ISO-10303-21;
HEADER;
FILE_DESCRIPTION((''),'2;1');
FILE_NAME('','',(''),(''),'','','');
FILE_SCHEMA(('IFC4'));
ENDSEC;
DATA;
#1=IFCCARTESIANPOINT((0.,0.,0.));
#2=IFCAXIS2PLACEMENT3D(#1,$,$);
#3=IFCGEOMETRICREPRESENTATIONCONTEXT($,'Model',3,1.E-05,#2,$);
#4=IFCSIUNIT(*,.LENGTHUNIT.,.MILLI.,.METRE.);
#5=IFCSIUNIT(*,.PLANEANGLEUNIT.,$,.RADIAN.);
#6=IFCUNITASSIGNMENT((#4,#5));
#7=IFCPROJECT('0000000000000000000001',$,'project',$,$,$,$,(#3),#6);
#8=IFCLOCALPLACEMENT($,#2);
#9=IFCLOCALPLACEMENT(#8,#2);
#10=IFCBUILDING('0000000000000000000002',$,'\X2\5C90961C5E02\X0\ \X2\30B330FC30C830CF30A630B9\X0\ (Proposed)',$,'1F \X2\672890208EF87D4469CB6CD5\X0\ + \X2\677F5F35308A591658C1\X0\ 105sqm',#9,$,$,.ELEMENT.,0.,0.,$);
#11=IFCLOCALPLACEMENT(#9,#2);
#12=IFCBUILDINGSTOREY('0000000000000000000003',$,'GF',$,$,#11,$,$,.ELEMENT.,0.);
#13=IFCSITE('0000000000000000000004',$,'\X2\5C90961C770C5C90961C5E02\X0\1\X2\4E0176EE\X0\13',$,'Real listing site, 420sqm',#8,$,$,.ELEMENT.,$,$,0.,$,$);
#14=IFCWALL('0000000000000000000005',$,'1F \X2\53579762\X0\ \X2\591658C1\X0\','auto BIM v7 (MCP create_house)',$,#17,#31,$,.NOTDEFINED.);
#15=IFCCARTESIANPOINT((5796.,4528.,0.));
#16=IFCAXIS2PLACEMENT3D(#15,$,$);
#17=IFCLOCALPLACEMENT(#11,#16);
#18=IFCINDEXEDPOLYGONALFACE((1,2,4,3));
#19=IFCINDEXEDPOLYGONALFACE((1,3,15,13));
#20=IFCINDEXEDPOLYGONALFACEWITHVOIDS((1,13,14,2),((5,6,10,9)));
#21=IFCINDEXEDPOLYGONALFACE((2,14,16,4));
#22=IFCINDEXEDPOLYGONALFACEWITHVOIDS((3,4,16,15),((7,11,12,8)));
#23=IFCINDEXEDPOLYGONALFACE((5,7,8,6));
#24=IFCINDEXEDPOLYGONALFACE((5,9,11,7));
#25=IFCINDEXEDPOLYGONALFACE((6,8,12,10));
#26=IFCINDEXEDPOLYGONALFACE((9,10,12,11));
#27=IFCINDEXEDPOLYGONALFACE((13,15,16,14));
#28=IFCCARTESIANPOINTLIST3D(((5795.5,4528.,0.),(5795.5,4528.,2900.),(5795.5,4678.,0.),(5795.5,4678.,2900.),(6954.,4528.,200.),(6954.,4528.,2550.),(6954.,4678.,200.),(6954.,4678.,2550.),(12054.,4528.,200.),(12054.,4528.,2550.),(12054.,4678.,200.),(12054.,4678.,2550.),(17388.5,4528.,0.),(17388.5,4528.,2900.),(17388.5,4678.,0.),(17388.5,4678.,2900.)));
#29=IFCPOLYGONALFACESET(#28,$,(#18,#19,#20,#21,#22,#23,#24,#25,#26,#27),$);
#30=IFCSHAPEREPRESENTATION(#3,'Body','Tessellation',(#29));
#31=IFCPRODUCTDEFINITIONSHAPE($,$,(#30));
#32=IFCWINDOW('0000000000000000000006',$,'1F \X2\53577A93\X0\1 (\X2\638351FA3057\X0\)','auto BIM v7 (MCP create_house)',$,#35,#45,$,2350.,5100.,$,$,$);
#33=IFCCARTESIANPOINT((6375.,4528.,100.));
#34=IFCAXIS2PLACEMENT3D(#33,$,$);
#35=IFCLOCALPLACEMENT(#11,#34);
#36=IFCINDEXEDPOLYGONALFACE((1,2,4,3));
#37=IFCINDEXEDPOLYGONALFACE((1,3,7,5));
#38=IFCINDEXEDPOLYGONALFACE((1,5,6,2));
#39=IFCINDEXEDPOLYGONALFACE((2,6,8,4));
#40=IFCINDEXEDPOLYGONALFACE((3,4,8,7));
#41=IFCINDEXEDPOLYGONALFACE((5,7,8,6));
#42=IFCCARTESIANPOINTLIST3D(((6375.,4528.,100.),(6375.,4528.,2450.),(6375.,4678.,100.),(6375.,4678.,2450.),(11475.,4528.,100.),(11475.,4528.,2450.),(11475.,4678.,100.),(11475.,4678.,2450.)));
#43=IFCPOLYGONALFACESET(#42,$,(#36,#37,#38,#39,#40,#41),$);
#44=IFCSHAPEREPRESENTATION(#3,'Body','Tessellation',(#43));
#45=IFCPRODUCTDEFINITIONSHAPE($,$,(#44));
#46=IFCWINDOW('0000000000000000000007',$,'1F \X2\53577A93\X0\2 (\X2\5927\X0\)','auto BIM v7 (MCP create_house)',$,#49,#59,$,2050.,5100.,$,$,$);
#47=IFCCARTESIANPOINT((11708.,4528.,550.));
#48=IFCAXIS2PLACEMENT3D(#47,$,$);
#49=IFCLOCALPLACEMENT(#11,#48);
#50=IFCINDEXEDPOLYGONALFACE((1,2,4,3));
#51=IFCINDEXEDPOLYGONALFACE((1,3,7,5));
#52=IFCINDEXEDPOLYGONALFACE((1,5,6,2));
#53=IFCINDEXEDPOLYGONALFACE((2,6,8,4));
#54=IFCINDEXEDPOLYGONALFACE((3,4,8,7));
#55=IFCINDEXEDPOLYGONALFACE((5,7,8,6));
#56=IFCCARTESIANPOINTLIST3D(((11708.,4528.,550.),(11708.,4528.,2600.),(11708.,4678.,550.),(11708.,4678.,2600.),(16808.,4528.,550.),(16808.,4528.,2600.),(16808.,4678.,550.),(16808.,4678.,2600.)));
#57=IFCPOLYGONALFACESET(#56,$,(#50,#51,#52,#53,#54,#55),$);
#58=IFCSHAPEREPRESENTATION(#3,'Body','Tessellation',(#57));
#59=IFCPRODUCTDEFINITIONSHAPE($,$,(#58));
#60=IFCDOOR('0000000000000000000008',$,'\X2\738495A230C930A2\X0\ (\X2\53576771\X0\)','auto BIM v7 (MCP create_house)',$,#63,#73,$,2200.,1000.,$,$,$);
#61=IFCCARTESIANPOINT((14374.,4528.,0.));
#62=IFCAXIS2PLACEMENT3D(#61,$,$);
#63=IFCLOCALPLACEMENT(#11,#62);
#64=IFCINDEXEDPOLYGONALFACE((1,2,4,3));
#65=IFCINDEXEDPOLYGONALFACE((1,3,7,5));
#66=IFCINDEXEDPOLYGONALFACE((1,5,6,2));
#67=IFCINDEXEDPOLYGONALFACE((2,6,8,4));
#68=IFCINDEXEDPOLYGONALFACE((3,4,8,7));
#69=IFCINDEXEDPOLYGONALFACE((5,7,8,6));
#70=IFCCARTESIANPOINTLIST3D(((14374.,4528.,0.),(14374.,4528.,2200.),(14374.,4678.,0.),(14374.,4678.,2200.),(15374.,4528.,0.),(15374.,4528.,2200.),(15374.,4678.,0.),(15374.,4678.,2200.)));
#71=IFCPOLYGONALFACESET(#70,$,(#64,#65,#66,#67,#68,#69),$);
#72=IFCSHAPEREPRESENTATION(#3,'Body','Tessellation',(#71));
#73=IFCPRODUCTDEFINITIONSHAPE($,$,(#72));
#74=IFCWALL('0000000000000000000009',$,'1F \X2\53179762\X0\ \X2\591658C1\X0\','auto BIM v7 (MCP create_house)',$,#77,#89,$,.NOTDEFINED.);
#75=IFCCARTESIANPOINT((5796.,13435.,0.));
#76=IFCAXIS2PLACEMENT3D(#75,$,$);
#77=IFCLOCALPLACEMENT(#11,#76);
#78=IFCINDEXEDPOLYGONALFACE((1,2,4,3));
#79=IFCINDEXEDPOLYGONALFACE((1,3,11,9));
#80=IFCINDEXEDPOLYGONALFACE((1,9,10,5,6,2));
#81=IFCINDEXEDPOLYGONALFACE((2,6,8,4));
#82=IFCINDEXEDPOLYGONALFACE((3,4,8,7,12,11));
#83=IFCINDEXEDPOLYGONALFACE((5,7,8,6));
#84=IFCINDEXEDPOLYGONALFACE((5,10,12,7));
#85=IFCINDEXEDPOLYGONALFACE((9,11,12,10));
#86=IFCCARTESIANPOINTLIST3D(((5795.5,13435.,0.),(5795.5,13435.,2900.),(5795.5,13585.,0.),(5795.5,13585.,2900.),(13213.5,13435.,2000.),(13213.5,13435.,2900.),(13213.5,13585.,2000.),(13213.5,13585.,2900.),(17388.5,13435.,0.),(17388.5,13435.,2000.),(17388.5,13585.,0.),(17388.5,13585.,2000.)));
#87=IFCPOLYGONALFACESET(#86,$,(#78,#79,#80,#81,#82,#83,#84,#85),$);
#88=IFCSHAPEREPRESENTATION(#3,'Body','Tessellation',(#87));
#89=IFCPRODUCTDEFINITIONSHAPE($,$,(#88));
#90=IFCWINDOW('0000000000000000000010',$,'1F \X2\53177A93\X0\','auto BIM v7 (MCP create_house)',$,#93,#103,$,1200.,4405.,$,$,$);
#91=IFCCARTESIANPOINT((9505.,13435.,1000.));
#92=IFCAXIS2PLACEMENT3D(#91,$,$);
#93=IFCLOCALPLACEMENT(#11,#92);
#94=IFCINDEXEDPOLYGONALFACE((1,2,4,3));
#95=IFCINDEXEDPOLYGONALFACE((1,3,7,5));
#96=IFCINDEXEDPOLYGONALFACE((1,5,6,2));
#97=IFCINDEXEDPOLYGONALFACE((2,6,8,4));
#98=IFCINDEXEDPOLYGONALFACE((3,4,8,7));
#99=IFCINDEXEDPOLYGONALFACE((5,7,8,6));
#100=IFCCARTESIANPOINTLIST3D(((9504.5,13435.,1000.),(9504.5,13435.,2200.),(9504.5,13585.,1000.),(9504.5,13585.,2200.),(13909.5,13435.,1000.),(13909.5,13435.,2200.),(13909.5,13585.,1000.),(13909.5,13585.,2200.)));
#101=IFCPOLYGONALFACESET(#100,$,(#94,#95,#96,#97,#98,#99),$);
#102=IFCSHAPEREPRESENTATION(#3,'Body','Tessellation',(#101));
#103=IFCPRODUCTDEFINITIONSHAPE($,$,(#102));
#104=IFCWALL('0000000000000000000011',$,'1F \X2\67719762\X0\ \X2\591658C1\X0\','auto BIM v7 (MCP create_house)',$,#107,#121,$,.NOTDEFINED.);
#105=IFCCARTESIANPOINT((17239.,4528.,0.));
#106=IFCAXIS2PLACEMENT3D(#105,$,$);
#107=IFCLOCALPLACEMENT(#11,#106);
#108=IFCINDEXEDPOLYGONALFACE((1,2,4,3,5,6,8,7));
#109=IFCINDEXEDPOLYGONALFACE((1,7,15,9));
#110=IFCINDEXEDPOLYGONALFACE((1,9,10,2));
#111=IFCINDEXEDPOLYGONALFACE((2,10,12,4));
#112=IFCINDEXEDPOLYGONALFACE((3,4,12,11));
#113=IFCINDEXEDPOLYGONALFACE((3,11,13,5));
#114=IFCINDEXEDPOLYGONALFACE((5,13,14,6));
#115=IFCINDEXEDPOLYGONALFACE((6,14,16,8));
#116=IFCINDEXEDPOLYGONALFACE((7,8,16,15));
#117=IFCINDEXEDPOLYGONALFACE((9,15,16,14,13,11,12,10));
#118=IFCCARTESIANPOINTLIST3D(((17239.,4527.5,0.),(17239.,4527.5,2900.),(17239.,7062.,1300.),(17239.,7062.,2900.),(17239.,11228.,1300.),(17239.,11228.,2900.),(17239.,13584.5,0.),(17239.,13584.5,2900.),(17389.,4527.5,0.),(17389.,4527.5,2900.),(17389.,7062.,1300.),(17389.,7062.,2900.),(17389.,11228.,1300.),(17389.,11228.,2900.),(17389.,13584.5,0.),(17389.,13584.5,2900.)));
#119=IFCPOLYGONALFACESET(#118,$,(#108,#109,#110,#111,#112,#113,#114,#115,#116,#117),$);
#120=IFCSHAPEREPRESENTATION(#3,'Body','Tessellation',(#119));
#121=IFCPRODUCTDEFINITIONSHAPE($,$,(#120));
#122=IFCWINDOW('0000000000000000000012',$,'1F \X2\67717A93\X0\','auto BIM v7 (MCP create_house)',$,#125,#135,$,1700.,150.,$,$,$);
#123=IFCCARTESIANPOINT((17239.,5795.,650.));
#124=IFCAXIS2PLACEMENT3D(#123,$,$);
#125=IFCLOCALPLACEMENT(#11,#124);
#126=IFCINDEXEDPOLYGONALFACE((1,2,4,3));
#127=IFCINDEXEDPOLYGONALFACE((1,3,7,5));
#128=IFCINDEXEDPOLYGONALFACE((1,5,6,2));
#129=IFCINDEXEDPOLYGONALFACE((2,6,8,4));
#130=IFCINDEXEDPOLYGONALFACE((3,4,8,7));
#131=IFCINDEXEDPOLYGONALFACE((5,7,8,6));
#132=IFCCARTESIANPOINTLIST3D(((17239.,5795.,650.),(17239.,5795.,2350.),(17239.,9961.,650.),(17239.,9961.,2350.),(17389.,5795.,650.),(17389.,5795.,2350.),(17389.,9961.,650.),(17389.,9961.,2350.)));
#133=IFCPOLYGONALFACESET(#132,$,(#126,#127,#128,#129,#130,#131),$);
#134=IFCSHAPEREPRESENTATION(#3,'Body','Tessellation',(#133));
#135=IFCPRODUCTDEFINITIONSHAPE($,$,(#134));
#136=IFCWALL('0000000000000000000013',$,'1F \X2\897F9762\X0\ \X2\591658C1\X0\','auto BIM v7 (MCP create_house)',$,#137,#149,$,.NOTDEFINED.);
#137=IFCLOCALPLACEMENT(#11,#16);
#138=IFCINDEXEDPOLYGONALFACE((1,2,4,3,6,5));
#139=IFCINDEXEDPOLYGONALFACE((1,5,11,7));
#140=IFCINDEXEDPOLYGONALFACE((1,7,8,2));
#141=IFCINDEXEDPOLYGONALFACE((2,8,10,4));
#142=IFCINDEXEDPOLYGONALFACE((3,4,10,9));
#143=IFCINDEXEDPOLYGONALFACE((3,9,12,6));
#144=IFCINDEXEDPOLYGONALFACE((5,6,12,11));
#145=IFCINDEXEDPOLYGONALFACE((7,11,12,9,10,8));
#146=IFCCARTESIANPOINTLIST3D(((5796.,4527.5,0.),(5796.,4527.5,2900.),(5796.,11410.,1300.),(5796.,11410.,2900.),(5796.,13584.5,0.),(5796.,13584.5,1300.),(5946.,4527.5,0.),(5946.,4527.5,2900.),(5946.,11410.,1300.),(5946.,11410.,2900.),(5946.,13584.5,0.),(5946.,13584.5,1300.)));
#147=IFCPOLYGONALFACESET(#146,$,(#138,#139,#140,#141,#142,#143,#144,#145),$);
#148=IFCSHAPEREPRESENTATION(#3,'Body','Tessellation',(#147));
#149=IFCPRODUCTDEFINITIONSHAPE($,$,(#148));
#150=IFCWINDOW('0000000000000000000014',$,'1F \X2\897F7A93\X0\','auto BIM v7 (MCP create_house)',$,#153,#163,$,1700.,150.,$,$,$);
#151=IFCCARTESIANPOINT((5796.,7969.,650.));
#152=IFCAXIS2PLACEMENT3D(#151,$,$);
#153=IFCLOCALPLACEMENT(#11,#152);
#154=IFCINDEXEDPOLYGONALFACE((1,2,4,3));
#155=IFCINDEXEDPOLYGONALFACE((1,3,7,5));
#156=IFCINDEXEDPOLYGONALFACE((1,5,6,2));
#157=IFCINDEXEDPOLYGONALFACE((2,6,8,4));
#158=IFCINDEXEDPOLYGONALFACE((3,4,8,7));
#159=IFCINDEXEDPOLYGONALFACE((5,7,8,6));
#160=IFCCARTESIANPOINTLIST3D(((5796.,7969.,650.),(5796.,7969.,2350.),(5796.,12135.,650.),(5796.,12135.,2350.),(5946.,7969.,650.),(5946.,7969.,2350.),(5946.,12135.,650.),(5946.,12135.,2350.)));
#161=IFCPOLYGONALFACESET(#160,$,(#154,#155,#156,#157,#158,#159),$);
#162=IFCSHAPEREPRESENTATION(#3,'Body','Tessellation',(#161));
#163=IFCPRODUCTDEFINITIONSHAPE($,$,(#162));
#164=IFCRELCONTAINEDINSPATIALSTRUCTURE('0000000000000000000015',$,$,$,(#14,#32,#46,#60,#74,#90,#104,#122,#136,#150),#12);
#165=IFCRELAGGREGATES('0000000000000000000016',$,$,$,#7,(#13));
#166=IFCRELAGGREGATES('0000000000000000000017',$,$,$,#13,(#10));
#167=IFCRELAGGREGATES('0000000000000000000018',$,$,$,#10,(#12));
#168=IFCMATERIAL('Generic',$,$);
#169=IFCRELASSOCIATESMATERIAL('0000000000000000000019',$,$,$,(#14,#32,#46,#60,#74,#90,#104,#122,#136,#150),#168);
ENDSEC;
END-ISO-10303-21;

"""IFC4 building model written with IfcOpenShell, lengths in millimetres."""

from ifc_helpers import new_model, si_unit, frame, frame_2d, origin, place, context, project, spatial, rectangle, extrude, material, element, fill, save


model = new_model("IFC4")

# Units and contexts
model_context = context("Model", 3, precision=1e-05, world=origin())
ifc_project = project(units=[si_unit("LENGTHUNIT", "METRE", prefix="MILLI"), si_unit("PLANEANGLEUNIT", "RADIAN")], contexts=[model_context])

# Site, building, storey
site_placement = place(None, origin())
site = spatial("IfcSite", under=ifc_project, at=site_placement, Name="岐阜県岐阜市1丁目13", ObjectType="Real listing site, 420sqm", CompositionType="ELEMENT", RefElevation=0.0)
building_placement = place(site_placement, origin())
building = spatial("IfcBuilding", under=site, at=building_placement, Name="岐阜市 コートハウス (Proposed)", ObjectType="1F 木造軸組構法 + 板張り外壁 105sqm", CompositionType="ELEMENT", ElevationOfRefHeight=0.0, ElevationOfTerrain=0.0)
storey_placement = place(building_placement, origin())
storey = spatial("IfcBuildingStorey", under=building, at=storey_placement, Name="GF", CompositionType="ELEMENT", Elevation=0.0)

# Shared definitions
ifc_material = material(Name="Generic")

# Wall, openings, windows, door
wall_1_placement = place(storey_placement, frame((5796.0, 4528.0, 0.0)))
wall_1 = element("IfcWall", 1, at=wall_1_placement, inside=storey, material=ifc_material, Name="1F 南面 外壁", Description="auto BIM v7 (MCP create_house)", PredefinedType="NOTDEFINED", context=model_context, shape_type="SweptSolid", body=[
    extrude(rectangle(XDim=11593.0, YDim=150.0, at=frame_2d((5796.0, 75.0))), frame((5796.0, 4528.0, 0.0)), (0.0, 0.0, 1.0), 2900.0),
])
opening_1_placement = place(storey_placement, frame((6375.0, 4528.0, 100.0)))
opening_1 = element("IfcOpeningElement", 2, at=opening_1_placement, cuts=wall_1, PredefinedType="NOTDEFINED", context=model_context, shape_type="SweptSolid", body=[
    extrude(rectangle(XDim=5100.0, YDim=150.0, at=frame_2d((2550.0, 75.0))), frame((6375.0, 4528.0, 100.0)), (0.0, 0.0, 1.0), 2350.0),
])
opening_2_placement = place(storey_placement, frame((11708.0, 4528.0, 550.0)))
opening_2 = element("IfcOpeningElement", 3, at=opening_2_placement, cuts=wall_1, PredefinedType="NOTDEFINED", context=model_context, shape_type="SweptSolid", body=[
    extrude(rectangle(XDim=5100.0, YDim=150.0, at=frame_2d((2550.0, 75.0))), frame((11708.0, 4528.0, 550.0)), (0.0, 0.0, 1.0), 2050.0),
])
opening_3_placement = place(storey_placement, frame((14374.0, 4528.0, 0.0)))
opening_3 = element("IfcOpeningElement", 4, at=opening_3_placement, cuts=wall_1, PredefinedType="NOTDEFINED", context=model_context, shape_type="SweptSolid", body=[
    extrude(rectangle(XDim=1000.0, YDim=150.0, at=frame_2d((500.0, 75.0))), frame((14374.0, 4528.0, 0.0)), (0.0, 0.0, 1.0), 2200.0),
])
window_1_placement = place(storey_placement, frame((6375.0, 4528.0, 100.0)))
window_1 = element("IfcWindow", 5, at=window_1_placement, inside=storey, material=ifc_material, Name="1F 南窓1 (掃出し)", Description="auto BIM v7 (MCP create_house)", OverallHeight=2350.0, OverallWidth=5100.0, context=model_context, shape_type="SweptSolid", body=[
    extrude(rectangle(XDim=5100.0, YDim=150.0, at=frame_2d((2550.0, 75.0))), frame((6375.0, 4528.0, 100.0)), (0.0, 0.0, 1.0), 2350.0),
])
fill(opening_1, window_1)
window_2_placement = place(storey_placement, frame((11708.0, 4528.0, 550.0)))
window_2 = element("IfcWindow", 6, at=window_2_placement, inside=storey, material=ifc_material, Name="1F 南窓2 (大)", Description="auto BIM v7 (MCP create_house)", OverallHeight=2050.0, OverallWidth=5100.0, context=model_context, shape_type="SweptSolid", body=[
    extrude(rectangle(XDim=5100.0, YDim=150.0, at=frame_2d((2550.0, 75.0))), frame((11708.0, 4528.0, 550.0)), (0.0, 0.0, 1.0), 2050.0),
])
fill(opening_2, window_2)
door_placement = place(storey_placement, frame((14374.0, 4528.0, 0.0)))
door = element("IfcDoor", 7, at=door_placement, inside=storey, material=ifc_material, Name="玄関ドア (南東)", Description="auto BIM v7 (MCP create_house)", OverallHeight=2200.0, OverallWidth=1000.0, context=model_context, shape_type="SweptSolid", body=[
    extrude(rectangle(XDim=1000.0, YDim=150.0, at=frame_2d((500.0, 75.0))), frame((14374.0, 4528.0, 0.0)), (0.0, 0.0, 1.0), 2200.0),
])
fill(opening_3, door)

# Walls, openings, windows
wall_2_placement = place(storey_placement, frame((5796.0, 13435.0, 0.0)))
wall_2 = element("IfcWall", 8, at=wall_2_placement, inside=storey, material=ifc_material, Name="1F 北面 外壁", Description="auto BIM v7 (MCP create_house)", PredefinedType="NOTDEFINED", context=model_context, shape_type="SweptSolid", body=[
    extrude(rectangle(XDim=11593.0, YDim=150.0, at=frame_2d((5796.0, 75.0))), frame((5796.0, 13435.0, 0.0)), (0.0, 0.0, 1.0), 2900.0),
])
opening_4_placement = place(storey_placement, frame((9505.0, 13435.0, 1000.0)))
opening_4 = element("IfcOpeningElement", 9, at=opening_4_placement, cuts=wall_2, PredefinedType="NOTDEFINED", context=model_context, shape_type="SweptSolid", body=[
    extrude(rectangle(XDim=4405.0, YDim=150.0, at=frame_2d((2202.0, 75.0))), frame((9505.0, 13435.0, 1000.0)), (0.0, 0.0, 1.0), 1200.0),
])
window_3_placement = place(storey_placement, frame((9505.0, 13435.0, 1000.0)))
window_3 = element("IfcWindow", 10, at=window_3_placement, inside=storey, material=ifc_material, Name="1F 北窓", Description="auto BIM v7 (MCP create_house)", OverallHeight=1200.0, OverallWidth=4405.0, context=model_context, shape_type="SweptSolid", body=[
    extrude(rectangle(XDim=4405.0, YDim=150.0, at=frame_2d((2202.0, 75.0))), frame((9505.0, 13435.0, 1000.0)), (0.0, 0.0, 1.0), 1200.0),
])
fill(opening_4, window_3)
wall_3_placement = place(storey_placement, frame((17239.0, 4528.0, 0.0)))
wall_3 = element("IfcWall", 11, at=wall_3_placement, inside=storey, material=ifc_material, Name="1F 東面 外壁", Description="auto BIM v7 (MCP create_house)", PredefinedType="NOTDEFINED", context=model_context, shape_type="SweptSolid", body=[
    extrude(rectangle(XDim=150.0, YDim=9057.0, at=frame_2d((75.0, 4528.0))), frame((17239.0, 4528.0, 0.0)), (0.0, 0.0, 1.0), 2900.0),
])
opening_5_placement = place(storey_placement, frame((17239.0, 5795.0, 650.0)))
opening_5 = element("IfcOpeningElement", 12, at=opening_5_placement, cuts=wall_3, PredefinedType="NOTDEFINED", context=model_context, shape_type="SweptSolid", body=[
    extrude(rectangle(XDim=150.0, YDim=4166.0, at=frame_2d((75.0, 2083.0))), frame((17239.0, 5795.0, 650.0)), (0.0, 0.0, 1.0), 1700.0),
])
window_4_placement = place(storey_placement, frame((17239.0, 5795.0, 650.0)))
window_4 = element("IfcWindow", 13, at=window_4_placement, inside=storey, material=ifc_material, Name="1F 東窓", Description="auto BIM v7 (MCP create_house)", OverallHeight=1700.0, OverallWidth=150.0, context=model_context, shape_type="SweptSolid", body=[
    extrude(rectangle(XDim=150.0, YDim=4166.0, at=frame_2d((75.0, 2083.0))), frame((17239.0, 5795.0, 650.0)), (0.0, 0.0, 1.0), 1700.0),
])
fill(opening_5, window_4)
wall_4_placement = place(storey_placement, frame((5796.0, 4528.0, 0.0)))
wall_4 = element("IfcWall", 14, at=wall_4_placement, inside=storey, material=ifc_material, Name="1F 西面 外壁", Description="auto BIM v7 (MCP create_house)", PredefinedType="NOTDEFINED", context=model_context, shape_type="SweptSolid", body=[
    extrude(rectangle(XDim=150.0, YDim=9057.0, at=frame_2d((75.0, 4528.0))), frame((5796.0, 4528.0, 0.0)), (0.0, 0.0, 1.0), 2900.0),
])
opening_6_placement = place(storey_placement, frame((5796.0, 7969.0, 650.0)))
opening_6 = element("IfcOpeningElement", 15, at=opening_6_placement, cuts=wall_4, PredefinedType="NOTDEFINED", context=model_context, shape_type="SweptSolid", body=[
    extrude(rectangle(XDim=150.0, YDim=4166.0, at=frame_2d((75.0, 2083.0))), frame((5796.0, 7969.0, 650.0)), (0.0, 0.0, 1.0), 1700.0),
])
window_5_placement = place(storey_placement, frame((5796.0, 7969.0, 650.0)))
window_5 = element("IfcWindow", 16, at=window_5_placement, inside=storey, material=ifc_material, Name="1F 西窓", Description="auto BIM v7 (MCP create_house)", OverallHeight=1700.0, OverallWidth=150.0, context=model_context, shape_type="SweptSolid", body=[
    extrude(rectangle(XDim=150.0, YDim=4166.0, at=frame_2d((75.0, 2083.0))), frame((5796.0, 7969.0, 650.0)), (0.0, 0.0, 1.0), 1700.0),
])
fill(opening_6, window_5)

save(model, "model.ifc")
